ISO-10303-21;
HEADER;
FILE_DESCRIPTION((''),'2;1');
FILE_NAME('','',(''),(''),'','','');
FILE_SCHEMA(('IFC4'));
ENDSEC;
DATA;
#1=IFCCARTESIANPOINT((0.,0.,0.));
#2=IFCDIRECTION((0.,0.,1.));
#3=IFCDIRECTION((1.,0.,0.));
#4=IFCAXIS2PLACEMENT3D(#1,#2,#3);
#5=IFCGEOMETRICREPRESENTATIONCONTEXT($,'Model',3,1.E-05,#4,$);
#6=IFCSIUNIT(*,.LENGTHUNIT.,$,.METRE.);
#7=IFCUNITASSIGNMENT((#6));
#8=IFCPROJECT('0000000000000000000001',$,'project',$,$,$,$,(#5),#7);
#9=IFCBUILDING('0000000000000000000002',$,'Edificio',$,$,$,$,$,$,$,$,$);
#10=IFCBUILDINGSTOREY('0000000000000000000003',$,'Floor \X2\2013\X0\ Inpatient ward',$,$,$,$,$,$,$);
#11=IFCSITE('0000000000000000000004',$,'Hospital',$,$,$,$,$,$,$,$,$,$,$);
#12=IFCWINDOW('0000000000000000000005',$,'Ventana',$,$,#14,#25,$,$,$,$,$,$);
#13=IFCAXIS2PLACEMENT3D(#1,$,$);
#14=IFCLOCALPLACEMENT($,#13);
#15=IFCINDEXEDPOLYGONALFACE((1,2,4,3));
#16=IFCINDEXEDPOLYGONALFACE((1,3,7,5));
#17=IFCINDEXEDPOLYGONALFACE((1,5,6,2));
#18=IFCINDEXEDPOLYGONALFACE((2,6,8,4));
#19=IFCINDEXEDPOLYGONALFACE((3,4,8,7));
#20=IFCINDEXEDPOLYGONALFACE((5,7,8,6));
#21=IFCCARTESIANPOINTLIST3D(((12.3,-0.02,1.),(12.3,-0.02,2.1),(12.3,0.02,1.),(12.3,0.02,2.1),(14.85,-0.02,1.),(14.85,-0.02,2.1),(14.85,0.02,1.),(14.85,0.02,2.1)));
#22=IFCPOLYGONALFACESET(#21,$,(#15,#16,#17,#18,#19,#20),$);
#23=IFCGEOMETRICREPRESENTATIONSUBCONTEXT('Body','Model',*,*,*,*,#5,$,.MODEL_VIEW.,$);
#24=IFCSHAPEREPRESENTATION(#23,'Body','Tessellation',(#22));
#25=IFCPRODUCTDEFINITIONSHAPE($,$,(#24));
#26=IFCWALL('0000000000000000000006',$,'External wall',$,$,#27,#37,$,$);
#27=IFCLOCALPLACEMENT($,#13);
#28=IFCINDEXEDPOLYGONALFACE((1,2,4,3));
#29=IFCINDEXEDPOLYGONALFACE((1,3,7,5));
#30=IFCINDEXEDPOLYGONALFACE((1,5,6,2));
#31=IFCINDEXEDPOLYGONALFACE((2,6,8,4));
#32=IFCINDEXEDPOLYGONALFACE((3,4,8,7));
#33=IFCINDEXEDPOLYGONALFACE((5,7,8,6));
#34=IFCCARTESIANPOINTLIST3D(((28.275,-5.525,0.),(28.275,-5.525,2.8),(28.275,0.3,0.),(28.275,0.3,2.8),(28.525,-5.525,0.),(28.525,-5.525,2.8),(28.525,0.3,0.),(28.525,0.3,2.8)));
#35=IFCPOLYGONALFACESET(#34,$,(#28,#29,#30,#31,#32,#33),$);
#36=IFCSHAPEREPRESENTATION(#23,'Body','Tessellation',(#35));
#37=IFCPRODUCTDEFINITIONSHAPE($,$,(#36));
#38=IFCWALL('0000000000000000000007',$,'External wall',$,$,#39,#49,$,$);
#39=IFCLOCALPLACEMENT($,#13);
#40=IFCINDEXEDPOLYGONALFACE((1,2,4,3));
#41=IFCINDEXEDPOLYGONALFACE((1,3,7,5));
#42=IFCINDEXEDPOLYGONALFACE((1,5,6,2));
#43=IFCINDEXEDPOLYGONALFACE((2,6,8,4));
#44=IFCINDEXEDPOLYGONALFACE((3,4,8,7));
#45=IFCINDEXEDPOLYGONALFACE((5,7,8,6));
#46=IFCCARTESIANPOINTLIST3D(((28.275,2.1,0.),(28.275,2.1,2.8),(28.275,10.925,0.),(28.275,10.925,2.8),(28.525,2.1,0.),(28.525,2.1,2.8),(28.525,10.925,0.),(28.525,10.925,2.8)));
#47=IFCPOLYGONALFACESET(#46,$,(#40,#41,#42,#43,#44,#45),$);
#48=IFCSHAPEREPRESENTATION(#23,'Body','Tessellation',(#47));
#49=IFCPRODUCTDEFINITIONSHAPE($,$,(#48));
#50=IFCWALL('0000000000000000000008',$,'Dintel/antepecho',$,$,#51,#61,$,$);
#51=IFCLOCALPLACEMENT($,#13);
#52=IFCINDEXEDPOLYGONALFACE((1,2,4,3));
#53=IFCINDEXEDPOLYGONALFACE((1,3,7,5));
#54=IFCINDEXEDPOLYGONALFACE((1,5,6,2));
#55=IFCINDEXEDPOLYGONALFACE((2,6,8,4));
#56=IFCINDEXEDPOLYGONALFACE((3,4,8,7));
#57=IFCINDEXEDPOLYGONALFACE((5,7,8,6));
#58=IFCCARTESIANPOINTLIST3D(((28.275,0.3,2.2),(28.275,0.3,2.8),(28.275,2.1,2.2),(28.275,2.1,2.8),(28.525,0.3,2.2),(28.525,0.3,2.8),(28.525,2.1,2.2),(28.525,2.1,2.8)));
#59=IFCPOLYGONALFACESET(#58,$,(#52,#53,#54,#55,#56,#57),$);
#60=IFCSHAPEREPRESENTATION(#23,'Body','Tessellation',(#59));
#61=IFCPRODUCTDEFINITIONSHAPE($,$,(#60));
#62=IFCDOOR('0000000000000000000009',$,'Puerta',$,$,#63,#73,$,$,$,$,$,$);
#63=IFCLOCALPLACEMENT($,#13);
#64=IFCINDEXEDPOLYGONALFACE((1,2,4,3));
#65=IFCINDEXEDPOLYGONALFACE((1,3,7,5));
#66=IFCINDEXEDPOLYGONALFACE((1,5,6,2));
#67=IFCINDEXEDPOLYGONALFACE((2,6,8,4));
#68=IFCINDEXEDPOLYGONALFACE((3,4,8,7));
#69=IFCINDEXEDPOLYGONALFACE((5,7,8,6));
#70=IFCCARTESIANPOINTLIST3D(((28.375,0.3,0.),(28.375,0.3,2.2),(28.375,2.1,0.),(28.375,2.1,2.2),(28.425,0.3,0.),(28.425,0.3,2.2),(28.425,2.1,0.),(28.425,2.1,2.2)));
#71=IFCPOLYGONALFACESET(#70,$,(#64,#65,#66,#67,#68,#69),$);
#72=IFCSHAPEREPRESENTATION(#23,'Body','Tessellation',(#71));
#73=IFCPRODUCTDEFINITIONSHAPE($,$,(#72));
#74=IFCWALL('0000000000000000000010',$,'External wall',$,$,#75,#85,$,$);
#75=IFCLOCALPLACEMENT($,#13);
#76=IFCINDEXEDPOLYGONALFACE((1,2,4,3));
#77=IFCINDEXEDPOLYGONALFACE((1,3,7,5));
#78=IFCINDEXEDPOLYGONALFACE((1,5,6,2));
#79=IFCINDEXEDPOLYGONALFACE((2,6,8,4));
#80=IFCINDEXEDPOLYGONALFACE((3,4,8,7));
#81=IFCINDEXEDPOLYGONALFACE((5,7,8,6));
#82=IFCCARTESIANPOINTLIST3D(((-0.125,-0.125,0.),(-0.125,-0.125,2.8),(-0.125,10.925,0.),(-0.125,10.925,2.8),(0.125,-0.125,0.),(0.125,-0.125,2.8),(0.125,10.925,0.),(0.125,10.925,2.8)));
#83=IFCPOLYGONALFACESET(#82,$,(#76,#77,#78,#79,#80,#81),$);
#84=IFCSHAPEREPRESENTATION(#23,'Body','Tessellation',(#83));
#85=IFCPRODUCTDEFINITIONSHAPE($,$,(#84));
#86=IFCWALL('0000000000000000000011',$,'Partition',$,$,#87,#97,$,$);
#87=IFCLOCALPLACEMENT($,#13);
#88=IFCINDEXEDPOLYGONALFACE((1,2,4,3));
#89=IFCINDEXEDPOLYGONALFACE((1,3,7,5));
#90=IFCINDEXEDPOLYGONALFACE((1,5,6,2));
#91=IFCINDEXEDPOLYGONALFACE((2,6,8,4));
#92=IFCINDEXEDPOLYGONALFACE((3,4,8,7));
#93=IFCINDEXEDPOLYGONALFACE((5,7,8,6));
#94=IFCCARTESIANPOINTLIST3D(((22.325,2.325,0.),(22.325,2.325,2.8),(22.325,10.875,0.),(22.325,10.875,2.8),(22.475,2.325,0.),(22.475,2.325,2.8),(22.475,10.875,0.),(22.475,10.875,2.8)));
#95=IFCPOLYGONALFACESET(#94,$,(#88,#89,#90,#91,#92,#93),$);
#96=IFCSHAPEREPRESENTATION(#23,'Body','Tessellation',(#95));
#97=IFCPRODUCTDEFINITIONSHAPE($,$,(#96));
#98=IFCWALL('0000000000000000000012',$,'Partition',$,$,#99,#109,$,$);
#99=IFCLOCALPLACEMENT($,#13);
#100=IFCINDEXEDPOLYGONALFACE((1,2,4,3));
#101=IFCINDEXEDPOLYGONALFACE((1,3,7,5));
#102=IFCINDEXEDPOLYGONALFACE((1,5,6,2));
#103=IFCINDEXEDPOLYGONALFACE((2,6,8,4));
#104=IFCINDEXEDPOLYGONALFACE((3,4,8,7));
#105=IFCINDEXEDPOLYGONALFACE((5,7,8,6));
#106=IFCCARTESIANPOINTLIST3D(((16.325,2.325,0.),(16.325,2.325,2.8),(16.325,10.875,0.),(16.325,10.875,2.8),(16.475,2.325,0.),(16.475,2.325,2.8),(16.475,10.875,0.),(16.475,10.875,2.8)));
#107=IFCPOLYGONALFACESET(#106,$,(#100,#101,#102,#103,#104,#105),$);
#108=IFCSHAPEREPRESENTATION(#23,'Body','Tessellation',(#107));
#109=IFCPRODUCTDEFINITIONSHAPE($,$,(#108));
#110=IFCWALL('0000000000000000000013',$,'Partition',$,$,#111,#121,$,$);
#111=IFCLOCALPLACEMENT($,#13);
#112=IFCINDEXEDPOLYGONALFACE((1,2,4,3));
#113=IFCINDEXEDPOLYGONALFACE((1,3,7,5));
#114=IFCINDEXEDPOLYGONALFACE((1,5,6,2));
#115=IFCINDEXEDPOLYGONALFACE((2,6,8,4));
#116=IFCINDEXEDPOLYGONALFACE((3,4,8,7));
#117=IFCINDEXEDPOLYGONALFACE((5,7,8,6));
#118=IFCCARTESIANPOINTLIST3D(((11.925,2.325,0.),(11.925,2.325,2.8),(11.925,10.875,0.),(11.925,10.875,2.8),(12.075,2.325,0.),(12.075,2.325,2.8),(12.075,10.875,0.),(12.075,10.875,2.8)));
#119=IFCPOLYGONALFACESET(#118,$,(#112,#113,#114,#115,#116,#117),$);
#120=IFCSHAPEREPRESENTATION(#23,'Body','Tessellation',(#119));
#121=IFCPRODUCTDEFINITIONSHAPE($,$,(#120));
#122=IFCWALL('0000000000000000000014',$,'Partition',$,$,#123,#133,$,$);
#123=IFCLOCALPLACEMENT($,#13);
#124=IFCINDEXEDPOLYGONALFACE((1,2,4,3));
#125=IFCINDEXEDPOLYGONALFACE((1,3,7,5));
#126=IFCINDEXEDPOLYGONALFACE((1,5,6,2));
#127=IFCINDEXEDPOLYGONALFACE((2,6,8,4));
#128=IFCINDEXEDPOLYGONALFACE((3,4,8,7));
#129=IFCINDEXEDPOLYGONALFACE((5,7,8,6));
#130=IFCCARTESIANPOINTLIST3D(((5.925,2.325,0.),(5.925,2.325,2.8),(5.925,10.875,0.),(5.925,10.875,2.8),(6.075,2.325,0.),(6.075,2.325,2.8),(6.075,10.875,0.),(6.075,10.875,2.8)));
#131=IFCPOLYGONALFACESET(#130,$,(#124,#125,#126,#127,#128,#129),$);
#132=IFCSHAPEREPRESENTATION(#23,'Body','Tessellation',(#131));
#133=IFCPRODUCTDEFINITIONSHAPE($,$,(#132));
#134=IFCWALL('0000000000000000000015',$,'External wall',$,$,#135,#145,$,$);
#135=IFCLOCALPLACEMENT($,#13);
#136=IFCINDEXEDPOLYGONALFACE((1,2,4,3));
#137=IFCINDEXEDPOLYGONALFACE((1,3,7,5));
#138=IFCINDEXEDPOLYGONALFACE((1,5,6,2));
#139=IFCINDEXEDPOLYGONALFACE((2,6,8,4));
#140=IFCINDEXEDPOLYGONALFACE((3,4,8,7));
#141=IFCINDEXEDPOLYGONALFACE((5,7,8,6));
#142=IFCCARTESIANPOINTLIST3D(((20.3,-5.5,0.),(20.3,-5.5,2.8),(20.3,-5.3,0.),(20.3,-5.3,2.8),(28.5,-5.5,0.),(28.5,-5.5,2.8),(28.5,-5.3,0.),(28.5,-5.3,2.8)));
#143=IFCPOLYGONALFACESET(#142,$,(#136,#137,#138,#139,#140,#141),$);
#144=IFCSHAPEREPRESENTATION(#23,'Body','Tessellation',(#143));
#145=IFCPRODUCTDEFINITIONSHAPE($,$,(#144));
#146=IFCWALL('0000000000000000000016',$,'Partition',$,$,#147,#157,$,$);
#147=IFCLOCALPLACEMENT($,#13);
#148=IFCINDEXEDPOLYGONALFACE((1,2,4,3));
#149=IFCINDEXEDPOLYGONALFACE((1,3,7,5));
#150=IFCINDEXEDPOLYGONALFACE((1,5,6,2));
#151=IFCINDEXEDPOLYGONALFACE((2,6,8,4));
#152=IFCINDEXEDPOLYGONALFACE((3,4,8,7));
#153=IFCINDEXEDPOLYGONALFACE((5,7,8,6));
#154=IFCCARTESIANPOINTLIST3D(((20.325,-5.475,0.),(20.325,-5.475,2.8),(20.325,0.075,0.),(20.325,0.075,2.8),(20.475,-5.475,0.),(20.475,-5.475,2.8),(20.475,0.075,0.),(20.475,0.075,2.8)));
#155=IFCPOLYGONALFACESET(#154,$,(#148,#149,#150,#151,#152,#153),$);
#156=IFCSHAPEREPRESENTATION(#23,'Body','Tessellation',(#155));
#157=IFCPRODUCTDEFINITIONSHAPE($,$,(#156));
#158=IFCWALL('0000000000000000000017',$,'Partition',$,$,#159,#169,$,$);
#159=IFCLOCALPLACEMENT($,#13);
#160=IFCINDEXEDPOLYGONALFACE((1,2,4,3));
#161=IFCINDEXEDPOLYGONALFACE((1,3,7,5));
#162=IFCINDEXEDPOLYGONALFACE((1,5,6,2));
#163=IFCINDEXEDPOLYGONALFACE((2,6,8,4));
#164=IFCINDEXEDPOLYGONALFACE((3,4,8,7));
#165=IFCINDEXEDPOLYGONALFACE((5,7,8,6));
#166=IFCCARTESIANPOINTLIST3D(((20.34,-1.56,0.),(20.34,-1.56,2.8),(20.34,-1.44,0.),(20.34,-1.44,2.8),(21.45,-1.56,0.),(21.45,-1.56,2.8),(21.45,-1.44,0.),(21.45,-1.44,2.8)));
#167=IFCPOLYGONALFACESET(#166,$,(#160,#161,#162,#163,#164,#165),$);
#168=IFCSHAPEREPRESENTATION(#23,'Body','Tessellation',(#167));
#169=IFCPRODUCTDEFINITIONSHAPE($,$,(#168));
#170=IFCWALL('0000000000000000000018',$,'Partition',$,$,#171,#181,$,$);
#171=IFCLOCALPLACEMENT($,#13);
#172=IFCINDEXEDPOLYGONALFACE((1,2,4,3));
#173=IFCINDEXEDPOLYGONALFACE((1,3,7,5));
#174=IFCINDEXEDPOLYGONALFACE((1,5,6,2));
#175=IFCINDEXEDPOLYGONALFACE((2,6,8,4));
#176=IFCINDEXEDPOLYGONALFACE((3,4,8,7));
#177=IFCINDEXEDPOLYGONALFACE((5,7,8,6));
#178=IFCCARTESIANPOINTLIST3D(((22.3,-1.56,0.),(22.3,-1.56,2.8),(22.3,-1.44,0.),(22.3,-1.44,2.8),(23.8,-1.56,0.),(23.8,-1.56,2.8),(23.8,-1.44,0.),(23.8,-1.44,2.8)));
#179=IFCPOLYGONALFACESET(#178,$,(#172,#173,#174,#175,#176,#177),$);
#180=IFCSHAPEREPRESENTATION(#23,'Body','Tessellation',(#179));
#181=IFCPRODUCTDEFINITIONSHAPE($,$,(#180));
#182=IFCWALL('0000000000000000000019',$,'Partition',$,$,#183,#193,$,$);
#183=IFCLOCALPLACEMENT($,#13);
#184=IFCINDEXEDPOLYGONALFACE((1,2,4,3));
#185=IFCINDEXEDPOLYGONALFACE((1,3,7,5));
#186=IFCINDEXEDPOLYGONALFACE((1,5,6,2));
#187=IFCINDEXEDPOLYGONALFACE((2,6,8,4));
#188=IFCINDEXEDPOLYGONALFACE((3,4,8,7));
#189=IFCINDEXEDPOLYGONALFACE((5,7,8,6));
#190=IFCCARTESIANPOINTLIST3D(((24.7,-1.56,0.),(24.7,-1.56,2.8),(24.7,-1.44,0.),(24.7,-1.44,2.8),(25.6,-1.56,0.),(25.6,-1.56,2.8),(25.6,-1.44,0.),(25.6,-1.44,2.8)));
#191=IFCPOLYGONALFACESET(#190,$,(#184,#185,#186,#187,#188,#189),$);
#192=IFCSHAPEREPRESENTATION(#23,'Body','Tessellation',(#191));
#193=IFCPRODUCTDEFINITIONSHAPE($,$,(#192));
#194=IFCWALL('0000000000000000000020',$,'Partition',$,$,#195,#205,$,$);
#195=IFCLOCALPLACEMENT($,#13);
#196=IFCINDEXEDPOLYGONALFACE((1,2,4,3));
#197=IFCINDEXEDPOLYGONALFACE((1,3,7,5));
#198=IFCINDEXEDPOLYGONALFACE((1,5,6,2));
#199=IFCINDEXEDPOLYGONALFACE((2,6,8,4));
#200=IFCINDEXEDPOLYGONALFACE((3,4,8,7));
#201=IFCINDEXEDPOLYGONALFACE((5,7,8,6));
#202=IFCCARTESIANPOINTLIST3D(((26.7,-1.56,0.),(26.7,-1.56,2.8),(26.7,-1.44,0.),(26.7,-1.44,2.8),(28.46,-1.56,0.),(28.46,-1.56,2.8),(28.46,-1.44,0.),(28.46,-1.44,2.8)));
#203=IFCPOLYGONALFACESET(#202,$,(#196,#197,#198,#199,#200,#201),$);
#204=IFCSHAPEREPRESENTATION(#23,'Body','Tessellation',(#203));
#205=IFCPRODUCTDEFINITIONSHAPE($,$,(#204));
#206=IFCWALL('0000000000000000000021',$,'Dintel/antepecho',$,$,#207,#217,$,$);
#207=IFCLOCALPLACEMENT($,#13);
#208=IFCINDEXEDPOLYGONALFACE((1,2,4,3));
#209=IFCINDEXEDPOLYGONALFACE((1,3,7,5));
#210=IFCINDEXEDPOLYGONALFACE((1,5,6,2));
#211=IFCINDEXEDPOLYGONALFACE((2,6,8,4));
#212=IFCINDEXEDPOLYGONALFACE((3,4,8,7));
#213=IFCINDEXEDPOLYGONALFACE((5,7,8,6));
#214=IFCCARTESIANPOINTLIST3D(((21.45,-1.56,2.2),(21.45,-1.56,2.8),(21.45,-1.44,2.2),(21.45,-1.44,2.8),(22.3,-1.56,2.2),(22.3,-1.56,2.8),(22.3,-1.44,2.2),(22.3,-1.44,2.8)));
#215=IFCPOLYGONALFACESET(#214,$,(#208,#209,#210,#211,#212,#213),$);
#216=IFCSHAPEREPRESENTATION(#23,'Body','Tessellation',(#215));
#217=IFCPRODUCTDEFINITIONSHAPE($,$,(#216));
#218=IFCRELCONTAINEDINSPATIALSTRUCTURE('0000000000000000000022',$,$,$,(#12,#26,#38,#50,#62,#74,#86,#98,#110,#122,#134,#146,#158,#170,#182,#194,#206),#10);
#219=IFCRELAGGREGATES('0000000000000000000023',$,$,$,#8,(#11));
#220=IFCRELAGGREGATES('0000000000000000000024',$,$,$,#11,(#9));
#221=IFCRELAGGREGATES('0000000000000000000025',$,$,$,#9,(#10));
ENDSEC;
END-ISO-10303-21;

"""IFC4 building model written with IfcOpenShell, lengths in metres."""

from ifc_helpers import new_model, si_unit, frame, origin_with_axes, context, subcontext, project, spatial, line, indexed_curve, outline, extrude, element, save


model = new_model("IFC4")

# Units and contexts
model_context = context("Model", 3, precision=1e-05, world=origin_with_axes())
body_context = subcontext(model_context, "Body", "Model", "MODEL_VIEW")
ifc_project = project(units=[si_unit("LENGTHUNIT", "METRE")], contexts=[model_context])

# Site, building, storey
site = spatial("IfcSite", under=ifc_project, Name="Hospital")
building = spatial("IfcBuilding", under=site, Name="Edificio")
storey = spatial("IfcBuildingStorey", under=building, Name="Floor – Inpatient ward")

# Window
element("IfcWindow", 1, inside=storey, Name="Ventana", context=body_context, shape_type="SweptSolid", body=[
    extrude(outline(indexed_curve([(0.0, 0.0), (2.55, 0.0), (2.55, 0.04), (0.0, 0.04)], segments=[line(1, 2, 3, 4, 1)])), frame((12.3, -0.02, 1.0), z_axis=(0.0, 0.0, 1.0), x_axis=(1.0, 0.0, 0.0)), (0.0, 0.0, 1.0), 1.1),
])

# Walls
element("IfcWall", 2, inside=storey, Name="External wall", context=body_context, shape_type="SweptSolid", body=[
    extrude(outline(indexed_curve([(0.0, 0.0), (0.25, 0.0), (0.25, 5.825), (0.0, 5.825)], segments=[line(1, 2, 3, 4, 1)])), frame((28.275, -5.525, 0.0), z_axis=(0.0, 0.0, 1.0), x_axis=(1.0, 0.0, 0.0)), (0.0, 0.0, 1.0), 2.8),
])
element("IfcWall", 3, inside=storey, Name="External wall", context=body_context, shape_type="SweptSolid", body=[
    extrude(outline(indexed_curve([(0.0, 0.0), (0.25, 0.0), (0.25, 8.825), (0.0, 8.825)], segments=[line(1, 2, 3, 4, 1)])), frame((28.275, 2.1, 0.0), z_axis=(0.0, 0.0, 1.0), x_axis=(1.0, 0.0, 0.0)), (0.0, 0.0, 1.0), 2.8),
])
element("IfcWall", 4, inside=storey, Name="Dintel/antepecho", context=body_context, shape_type="SweptSolid", body=[
    extrude(outline(indexed_curve([(0.0, 0.0), (0.25, 0.0), (0.25, 1.8), (0.0, 1.8)], segments=[line(1, 2, 3, 4, 1)])), frame((28.275, 0.3, 2.2), z_axis=(0.0, 0.0, 1.0), x_axis=(1.0, 0.0, 0.0)), (0.0, 0.0, 1.0), 0.6),
])

# Door
element("IfcDoor", 5, inside=storey, Name="Puerta", context=body_context, shape_type="SweptSolid", body=[
    extrude(outline(indexed_curve([(0.0, 0.0), (0.05, 0.0), (0.05, 1.8), (0.0, 1.8)], segments=[line(1, 2, 3, 4, 1)])), frame((28.375, 0.3, 0.0), z_axis=(0.0, 0.0, 1.0), x_axis=(1.0, 0.0, 0.0)), (0.0, 0.0, 1.0), 2.2),
])

# Walls
element("IfcWall", 6, inside=storey, Name="External wall", context=body_context, shape_type="SweptSolid", body=[
    extrude(outline(indexed_curve([(0.0, 0.0), (0.25, 0.0), (0.25, 11.05), (0.0, 11.05)], segments=[line(1, 2, 3, 4, 1)])), frame((-0.125, -0.125, 0.0), z_axis=(0.0, 0.0, 1.0), x_axis=(1.0, 0.0, 0.0)), (0.0, 0.0, 1.0), 2.8),
])
element("IfcWall", 7, inside=storey, Name="Partition", context=body_context, shape_type="SweptSolid", body=[
    extrude(outline(indexed_curve([(0.0, 0.0), (0.15, 0.0), (0.15, 8.55), (0.0, 8.55)], segments=[line(1, 2, 3, 4, 1)])), frame((22.325, 2.325, 0.0), z_axis=(0.0, 0.0, 1.0), x_axis=(1.0, 0.0, 0.0)), (0.0, 0.0, 1.0), 2.8),
])
element("IfcWall", 8, inside=storey, Name="Partition", context=body_context, shape_type="SweptSolid", body=[
    extrude(outline(indexed_curve([(0.0, 0.0), (0.15, 0.0), (0.15, 8.55), (0.0, 8.55)], segments=[line(1, 2, 3, 4, 1)])), frame((16.325, 2.325, 0.0), z_axis=(0.0, 0.0, 1.0), x_axis=(1.0, 0.0, 0.0)), (0.0, 0.0, 1.0), 2.8),
])
element("IfcWall", 9, inside=storey, Name="Partition", context=body_context, shape_type="SweptSolid", body=[
    extrude(outline(indexed_curve([(0.0, 0.0), (0.15, 0.0), (0.15, 8.55), (0.0, 8.55)], segments=[line(1, 2, 3, 4, 1)])), frame((11.925, 2.325, 0.0), z_axis=(0.0, 0.0, 1.0), x_axis=(1.0, 0.0, 0.0)), (0.0, 0.0, 1.0), 2.8),
])
element("IfcWall", 10, inside=storey, Name="Partition", context=body_context, shape_type="SweptSolid", body=[
    extrude(outline(indexed_curve([(0.0, 0.0), (0.15, 0.0), (0.15, 8.55), (0.0, 8.55)], segments=[line(1, 2, 3, 4, 1)])), frame((5.925, 2.325, 0.0), z_axis=(0.0, 0.0, 1.0), x_axis=(1.0, 0.0, 0.0)), (0.0, 0.0, 1.0), 2.8),
])
element("IfcWall", 11, inside=storey, Name="External wall", context=body_context, shape_type="SweptSolid", body=[
    extrude(outline(indexed_curve([(0.0, 0.0), (8.2, 0.0), (8.2, 0.2), (0.0, 0.2)], segments=[line(1, 2, 3, 4, 1)])), frame((20.3, -5.5, 0.0), z_axis=(0.0, 0.0, 1.0), x_axis=(1.0, 0.0, 0.0)), (0.0, 0.0, 1.0), 2.8),
])
element("IfcWall", 12, inside=storey, Name="Partition", context=body_context, shape_type="SweptSolid", body=[
    extrude(outline(indexed_curve([(0.0, 0.0), (0.15, 0.0), (0.15, 5.55), (0.0, 5.55)], segments=[line(1, 2, 3, 4, 1)])), frame((20.325, -5.475, 0.0), z_axis=(0.0, 0.0, 1.0), x_axis=(1.0, 0.0, 0.0)), (0.0, 0.0, 1.0), 2.8),
])
element("IfcWall", 13, inside=storey, Name="Partition", context=body_context, shape_type="SweptSolid", body=[
    extrude(outline(indexed_curve([(0.0, 0.0), (1.11, 0.0), (1.11, 0.12), (0.0, 0.12)], segments=[line(1, 2, 3, 4, 1)])), frame((20.34, -1.56, 0.0), z_axis=(0.0, 0.0, 1.0), x_axis=(1.0, 0.0, 0.0)), (0.0, 0.0, 1.0), 2.8),
])
element("IfcWall", 14, inside=storey, Name="Partition", context=body_context, shape_type="SweptSolid", body=[
    extrude(outline(indexed_curve([(0.0, 0.0), (1.5, 0.0), (1.5, 0.12), (0.0, 0.12)], segments=[line(1, 2, 3, 4, 1)])), frame((22.3, -1.56, 0.0), z_axis=(0.0, 0.0, 1.0), x_axis=(1.0, 0.0, 0.0)), (0.0, 0.0, 1.0), 2.8),
])
element("IfcWall", 15, inside=storey, Name="Partition", context=body_context, shape_type="SweptSolid", body=[
    extrude(outline(indexed_curve([(0.0, 0.0), (0.9, 0.0), (0.9, 0.12), (0.0, 0.12)], segments=[line(1, 2, 3, 4, 1)])), frame((24.7, -1.56, 0.0), z_axis=(0.0, 0.0, 1.0), x_axis=(1.0, 0.0, 0.0)), (0.0, 0.0, 1.0), 2.8),
])
element("IfcWall", 16, inside=storey, Name="Partition", context=body_context, shape_type="SweptSolid", body=[
    extrude(outline(indexed_curve([(0.0, 0.0), (1.76, 0.0), (1.76, 0.12), (0.0, 0.12)], segments=[line(1, 2, 3, 4, 1)])), frame((26.7, -1.56, 0.0), z_axis=(0.0, 0.0, 1.0), x_axis=(1.0, 0.0, 0.0)), (0.0, 0.0, 1.0), 2.8),
])
element("IfcWall", 17, inside=storey, Name="Dintel/antepecho", context=body_context, shape_type="SweptSolid", body=[
    extrude(outline(indexed_curve([(0.0, 0.0), (0.85, 0.0), (0.85, 0.12), (0.0, 0.12)], segments=[line(1, 2, 3, 4, 1)])), frame((21.45, -1.56, 2.2), z_axis=(0.0, 0.0, 1.0), x_axis=(1.0, 0.0, 0.0)), (0.0, 0.0, 1.0), 0.6),
])

save(model, "model.ifc")
